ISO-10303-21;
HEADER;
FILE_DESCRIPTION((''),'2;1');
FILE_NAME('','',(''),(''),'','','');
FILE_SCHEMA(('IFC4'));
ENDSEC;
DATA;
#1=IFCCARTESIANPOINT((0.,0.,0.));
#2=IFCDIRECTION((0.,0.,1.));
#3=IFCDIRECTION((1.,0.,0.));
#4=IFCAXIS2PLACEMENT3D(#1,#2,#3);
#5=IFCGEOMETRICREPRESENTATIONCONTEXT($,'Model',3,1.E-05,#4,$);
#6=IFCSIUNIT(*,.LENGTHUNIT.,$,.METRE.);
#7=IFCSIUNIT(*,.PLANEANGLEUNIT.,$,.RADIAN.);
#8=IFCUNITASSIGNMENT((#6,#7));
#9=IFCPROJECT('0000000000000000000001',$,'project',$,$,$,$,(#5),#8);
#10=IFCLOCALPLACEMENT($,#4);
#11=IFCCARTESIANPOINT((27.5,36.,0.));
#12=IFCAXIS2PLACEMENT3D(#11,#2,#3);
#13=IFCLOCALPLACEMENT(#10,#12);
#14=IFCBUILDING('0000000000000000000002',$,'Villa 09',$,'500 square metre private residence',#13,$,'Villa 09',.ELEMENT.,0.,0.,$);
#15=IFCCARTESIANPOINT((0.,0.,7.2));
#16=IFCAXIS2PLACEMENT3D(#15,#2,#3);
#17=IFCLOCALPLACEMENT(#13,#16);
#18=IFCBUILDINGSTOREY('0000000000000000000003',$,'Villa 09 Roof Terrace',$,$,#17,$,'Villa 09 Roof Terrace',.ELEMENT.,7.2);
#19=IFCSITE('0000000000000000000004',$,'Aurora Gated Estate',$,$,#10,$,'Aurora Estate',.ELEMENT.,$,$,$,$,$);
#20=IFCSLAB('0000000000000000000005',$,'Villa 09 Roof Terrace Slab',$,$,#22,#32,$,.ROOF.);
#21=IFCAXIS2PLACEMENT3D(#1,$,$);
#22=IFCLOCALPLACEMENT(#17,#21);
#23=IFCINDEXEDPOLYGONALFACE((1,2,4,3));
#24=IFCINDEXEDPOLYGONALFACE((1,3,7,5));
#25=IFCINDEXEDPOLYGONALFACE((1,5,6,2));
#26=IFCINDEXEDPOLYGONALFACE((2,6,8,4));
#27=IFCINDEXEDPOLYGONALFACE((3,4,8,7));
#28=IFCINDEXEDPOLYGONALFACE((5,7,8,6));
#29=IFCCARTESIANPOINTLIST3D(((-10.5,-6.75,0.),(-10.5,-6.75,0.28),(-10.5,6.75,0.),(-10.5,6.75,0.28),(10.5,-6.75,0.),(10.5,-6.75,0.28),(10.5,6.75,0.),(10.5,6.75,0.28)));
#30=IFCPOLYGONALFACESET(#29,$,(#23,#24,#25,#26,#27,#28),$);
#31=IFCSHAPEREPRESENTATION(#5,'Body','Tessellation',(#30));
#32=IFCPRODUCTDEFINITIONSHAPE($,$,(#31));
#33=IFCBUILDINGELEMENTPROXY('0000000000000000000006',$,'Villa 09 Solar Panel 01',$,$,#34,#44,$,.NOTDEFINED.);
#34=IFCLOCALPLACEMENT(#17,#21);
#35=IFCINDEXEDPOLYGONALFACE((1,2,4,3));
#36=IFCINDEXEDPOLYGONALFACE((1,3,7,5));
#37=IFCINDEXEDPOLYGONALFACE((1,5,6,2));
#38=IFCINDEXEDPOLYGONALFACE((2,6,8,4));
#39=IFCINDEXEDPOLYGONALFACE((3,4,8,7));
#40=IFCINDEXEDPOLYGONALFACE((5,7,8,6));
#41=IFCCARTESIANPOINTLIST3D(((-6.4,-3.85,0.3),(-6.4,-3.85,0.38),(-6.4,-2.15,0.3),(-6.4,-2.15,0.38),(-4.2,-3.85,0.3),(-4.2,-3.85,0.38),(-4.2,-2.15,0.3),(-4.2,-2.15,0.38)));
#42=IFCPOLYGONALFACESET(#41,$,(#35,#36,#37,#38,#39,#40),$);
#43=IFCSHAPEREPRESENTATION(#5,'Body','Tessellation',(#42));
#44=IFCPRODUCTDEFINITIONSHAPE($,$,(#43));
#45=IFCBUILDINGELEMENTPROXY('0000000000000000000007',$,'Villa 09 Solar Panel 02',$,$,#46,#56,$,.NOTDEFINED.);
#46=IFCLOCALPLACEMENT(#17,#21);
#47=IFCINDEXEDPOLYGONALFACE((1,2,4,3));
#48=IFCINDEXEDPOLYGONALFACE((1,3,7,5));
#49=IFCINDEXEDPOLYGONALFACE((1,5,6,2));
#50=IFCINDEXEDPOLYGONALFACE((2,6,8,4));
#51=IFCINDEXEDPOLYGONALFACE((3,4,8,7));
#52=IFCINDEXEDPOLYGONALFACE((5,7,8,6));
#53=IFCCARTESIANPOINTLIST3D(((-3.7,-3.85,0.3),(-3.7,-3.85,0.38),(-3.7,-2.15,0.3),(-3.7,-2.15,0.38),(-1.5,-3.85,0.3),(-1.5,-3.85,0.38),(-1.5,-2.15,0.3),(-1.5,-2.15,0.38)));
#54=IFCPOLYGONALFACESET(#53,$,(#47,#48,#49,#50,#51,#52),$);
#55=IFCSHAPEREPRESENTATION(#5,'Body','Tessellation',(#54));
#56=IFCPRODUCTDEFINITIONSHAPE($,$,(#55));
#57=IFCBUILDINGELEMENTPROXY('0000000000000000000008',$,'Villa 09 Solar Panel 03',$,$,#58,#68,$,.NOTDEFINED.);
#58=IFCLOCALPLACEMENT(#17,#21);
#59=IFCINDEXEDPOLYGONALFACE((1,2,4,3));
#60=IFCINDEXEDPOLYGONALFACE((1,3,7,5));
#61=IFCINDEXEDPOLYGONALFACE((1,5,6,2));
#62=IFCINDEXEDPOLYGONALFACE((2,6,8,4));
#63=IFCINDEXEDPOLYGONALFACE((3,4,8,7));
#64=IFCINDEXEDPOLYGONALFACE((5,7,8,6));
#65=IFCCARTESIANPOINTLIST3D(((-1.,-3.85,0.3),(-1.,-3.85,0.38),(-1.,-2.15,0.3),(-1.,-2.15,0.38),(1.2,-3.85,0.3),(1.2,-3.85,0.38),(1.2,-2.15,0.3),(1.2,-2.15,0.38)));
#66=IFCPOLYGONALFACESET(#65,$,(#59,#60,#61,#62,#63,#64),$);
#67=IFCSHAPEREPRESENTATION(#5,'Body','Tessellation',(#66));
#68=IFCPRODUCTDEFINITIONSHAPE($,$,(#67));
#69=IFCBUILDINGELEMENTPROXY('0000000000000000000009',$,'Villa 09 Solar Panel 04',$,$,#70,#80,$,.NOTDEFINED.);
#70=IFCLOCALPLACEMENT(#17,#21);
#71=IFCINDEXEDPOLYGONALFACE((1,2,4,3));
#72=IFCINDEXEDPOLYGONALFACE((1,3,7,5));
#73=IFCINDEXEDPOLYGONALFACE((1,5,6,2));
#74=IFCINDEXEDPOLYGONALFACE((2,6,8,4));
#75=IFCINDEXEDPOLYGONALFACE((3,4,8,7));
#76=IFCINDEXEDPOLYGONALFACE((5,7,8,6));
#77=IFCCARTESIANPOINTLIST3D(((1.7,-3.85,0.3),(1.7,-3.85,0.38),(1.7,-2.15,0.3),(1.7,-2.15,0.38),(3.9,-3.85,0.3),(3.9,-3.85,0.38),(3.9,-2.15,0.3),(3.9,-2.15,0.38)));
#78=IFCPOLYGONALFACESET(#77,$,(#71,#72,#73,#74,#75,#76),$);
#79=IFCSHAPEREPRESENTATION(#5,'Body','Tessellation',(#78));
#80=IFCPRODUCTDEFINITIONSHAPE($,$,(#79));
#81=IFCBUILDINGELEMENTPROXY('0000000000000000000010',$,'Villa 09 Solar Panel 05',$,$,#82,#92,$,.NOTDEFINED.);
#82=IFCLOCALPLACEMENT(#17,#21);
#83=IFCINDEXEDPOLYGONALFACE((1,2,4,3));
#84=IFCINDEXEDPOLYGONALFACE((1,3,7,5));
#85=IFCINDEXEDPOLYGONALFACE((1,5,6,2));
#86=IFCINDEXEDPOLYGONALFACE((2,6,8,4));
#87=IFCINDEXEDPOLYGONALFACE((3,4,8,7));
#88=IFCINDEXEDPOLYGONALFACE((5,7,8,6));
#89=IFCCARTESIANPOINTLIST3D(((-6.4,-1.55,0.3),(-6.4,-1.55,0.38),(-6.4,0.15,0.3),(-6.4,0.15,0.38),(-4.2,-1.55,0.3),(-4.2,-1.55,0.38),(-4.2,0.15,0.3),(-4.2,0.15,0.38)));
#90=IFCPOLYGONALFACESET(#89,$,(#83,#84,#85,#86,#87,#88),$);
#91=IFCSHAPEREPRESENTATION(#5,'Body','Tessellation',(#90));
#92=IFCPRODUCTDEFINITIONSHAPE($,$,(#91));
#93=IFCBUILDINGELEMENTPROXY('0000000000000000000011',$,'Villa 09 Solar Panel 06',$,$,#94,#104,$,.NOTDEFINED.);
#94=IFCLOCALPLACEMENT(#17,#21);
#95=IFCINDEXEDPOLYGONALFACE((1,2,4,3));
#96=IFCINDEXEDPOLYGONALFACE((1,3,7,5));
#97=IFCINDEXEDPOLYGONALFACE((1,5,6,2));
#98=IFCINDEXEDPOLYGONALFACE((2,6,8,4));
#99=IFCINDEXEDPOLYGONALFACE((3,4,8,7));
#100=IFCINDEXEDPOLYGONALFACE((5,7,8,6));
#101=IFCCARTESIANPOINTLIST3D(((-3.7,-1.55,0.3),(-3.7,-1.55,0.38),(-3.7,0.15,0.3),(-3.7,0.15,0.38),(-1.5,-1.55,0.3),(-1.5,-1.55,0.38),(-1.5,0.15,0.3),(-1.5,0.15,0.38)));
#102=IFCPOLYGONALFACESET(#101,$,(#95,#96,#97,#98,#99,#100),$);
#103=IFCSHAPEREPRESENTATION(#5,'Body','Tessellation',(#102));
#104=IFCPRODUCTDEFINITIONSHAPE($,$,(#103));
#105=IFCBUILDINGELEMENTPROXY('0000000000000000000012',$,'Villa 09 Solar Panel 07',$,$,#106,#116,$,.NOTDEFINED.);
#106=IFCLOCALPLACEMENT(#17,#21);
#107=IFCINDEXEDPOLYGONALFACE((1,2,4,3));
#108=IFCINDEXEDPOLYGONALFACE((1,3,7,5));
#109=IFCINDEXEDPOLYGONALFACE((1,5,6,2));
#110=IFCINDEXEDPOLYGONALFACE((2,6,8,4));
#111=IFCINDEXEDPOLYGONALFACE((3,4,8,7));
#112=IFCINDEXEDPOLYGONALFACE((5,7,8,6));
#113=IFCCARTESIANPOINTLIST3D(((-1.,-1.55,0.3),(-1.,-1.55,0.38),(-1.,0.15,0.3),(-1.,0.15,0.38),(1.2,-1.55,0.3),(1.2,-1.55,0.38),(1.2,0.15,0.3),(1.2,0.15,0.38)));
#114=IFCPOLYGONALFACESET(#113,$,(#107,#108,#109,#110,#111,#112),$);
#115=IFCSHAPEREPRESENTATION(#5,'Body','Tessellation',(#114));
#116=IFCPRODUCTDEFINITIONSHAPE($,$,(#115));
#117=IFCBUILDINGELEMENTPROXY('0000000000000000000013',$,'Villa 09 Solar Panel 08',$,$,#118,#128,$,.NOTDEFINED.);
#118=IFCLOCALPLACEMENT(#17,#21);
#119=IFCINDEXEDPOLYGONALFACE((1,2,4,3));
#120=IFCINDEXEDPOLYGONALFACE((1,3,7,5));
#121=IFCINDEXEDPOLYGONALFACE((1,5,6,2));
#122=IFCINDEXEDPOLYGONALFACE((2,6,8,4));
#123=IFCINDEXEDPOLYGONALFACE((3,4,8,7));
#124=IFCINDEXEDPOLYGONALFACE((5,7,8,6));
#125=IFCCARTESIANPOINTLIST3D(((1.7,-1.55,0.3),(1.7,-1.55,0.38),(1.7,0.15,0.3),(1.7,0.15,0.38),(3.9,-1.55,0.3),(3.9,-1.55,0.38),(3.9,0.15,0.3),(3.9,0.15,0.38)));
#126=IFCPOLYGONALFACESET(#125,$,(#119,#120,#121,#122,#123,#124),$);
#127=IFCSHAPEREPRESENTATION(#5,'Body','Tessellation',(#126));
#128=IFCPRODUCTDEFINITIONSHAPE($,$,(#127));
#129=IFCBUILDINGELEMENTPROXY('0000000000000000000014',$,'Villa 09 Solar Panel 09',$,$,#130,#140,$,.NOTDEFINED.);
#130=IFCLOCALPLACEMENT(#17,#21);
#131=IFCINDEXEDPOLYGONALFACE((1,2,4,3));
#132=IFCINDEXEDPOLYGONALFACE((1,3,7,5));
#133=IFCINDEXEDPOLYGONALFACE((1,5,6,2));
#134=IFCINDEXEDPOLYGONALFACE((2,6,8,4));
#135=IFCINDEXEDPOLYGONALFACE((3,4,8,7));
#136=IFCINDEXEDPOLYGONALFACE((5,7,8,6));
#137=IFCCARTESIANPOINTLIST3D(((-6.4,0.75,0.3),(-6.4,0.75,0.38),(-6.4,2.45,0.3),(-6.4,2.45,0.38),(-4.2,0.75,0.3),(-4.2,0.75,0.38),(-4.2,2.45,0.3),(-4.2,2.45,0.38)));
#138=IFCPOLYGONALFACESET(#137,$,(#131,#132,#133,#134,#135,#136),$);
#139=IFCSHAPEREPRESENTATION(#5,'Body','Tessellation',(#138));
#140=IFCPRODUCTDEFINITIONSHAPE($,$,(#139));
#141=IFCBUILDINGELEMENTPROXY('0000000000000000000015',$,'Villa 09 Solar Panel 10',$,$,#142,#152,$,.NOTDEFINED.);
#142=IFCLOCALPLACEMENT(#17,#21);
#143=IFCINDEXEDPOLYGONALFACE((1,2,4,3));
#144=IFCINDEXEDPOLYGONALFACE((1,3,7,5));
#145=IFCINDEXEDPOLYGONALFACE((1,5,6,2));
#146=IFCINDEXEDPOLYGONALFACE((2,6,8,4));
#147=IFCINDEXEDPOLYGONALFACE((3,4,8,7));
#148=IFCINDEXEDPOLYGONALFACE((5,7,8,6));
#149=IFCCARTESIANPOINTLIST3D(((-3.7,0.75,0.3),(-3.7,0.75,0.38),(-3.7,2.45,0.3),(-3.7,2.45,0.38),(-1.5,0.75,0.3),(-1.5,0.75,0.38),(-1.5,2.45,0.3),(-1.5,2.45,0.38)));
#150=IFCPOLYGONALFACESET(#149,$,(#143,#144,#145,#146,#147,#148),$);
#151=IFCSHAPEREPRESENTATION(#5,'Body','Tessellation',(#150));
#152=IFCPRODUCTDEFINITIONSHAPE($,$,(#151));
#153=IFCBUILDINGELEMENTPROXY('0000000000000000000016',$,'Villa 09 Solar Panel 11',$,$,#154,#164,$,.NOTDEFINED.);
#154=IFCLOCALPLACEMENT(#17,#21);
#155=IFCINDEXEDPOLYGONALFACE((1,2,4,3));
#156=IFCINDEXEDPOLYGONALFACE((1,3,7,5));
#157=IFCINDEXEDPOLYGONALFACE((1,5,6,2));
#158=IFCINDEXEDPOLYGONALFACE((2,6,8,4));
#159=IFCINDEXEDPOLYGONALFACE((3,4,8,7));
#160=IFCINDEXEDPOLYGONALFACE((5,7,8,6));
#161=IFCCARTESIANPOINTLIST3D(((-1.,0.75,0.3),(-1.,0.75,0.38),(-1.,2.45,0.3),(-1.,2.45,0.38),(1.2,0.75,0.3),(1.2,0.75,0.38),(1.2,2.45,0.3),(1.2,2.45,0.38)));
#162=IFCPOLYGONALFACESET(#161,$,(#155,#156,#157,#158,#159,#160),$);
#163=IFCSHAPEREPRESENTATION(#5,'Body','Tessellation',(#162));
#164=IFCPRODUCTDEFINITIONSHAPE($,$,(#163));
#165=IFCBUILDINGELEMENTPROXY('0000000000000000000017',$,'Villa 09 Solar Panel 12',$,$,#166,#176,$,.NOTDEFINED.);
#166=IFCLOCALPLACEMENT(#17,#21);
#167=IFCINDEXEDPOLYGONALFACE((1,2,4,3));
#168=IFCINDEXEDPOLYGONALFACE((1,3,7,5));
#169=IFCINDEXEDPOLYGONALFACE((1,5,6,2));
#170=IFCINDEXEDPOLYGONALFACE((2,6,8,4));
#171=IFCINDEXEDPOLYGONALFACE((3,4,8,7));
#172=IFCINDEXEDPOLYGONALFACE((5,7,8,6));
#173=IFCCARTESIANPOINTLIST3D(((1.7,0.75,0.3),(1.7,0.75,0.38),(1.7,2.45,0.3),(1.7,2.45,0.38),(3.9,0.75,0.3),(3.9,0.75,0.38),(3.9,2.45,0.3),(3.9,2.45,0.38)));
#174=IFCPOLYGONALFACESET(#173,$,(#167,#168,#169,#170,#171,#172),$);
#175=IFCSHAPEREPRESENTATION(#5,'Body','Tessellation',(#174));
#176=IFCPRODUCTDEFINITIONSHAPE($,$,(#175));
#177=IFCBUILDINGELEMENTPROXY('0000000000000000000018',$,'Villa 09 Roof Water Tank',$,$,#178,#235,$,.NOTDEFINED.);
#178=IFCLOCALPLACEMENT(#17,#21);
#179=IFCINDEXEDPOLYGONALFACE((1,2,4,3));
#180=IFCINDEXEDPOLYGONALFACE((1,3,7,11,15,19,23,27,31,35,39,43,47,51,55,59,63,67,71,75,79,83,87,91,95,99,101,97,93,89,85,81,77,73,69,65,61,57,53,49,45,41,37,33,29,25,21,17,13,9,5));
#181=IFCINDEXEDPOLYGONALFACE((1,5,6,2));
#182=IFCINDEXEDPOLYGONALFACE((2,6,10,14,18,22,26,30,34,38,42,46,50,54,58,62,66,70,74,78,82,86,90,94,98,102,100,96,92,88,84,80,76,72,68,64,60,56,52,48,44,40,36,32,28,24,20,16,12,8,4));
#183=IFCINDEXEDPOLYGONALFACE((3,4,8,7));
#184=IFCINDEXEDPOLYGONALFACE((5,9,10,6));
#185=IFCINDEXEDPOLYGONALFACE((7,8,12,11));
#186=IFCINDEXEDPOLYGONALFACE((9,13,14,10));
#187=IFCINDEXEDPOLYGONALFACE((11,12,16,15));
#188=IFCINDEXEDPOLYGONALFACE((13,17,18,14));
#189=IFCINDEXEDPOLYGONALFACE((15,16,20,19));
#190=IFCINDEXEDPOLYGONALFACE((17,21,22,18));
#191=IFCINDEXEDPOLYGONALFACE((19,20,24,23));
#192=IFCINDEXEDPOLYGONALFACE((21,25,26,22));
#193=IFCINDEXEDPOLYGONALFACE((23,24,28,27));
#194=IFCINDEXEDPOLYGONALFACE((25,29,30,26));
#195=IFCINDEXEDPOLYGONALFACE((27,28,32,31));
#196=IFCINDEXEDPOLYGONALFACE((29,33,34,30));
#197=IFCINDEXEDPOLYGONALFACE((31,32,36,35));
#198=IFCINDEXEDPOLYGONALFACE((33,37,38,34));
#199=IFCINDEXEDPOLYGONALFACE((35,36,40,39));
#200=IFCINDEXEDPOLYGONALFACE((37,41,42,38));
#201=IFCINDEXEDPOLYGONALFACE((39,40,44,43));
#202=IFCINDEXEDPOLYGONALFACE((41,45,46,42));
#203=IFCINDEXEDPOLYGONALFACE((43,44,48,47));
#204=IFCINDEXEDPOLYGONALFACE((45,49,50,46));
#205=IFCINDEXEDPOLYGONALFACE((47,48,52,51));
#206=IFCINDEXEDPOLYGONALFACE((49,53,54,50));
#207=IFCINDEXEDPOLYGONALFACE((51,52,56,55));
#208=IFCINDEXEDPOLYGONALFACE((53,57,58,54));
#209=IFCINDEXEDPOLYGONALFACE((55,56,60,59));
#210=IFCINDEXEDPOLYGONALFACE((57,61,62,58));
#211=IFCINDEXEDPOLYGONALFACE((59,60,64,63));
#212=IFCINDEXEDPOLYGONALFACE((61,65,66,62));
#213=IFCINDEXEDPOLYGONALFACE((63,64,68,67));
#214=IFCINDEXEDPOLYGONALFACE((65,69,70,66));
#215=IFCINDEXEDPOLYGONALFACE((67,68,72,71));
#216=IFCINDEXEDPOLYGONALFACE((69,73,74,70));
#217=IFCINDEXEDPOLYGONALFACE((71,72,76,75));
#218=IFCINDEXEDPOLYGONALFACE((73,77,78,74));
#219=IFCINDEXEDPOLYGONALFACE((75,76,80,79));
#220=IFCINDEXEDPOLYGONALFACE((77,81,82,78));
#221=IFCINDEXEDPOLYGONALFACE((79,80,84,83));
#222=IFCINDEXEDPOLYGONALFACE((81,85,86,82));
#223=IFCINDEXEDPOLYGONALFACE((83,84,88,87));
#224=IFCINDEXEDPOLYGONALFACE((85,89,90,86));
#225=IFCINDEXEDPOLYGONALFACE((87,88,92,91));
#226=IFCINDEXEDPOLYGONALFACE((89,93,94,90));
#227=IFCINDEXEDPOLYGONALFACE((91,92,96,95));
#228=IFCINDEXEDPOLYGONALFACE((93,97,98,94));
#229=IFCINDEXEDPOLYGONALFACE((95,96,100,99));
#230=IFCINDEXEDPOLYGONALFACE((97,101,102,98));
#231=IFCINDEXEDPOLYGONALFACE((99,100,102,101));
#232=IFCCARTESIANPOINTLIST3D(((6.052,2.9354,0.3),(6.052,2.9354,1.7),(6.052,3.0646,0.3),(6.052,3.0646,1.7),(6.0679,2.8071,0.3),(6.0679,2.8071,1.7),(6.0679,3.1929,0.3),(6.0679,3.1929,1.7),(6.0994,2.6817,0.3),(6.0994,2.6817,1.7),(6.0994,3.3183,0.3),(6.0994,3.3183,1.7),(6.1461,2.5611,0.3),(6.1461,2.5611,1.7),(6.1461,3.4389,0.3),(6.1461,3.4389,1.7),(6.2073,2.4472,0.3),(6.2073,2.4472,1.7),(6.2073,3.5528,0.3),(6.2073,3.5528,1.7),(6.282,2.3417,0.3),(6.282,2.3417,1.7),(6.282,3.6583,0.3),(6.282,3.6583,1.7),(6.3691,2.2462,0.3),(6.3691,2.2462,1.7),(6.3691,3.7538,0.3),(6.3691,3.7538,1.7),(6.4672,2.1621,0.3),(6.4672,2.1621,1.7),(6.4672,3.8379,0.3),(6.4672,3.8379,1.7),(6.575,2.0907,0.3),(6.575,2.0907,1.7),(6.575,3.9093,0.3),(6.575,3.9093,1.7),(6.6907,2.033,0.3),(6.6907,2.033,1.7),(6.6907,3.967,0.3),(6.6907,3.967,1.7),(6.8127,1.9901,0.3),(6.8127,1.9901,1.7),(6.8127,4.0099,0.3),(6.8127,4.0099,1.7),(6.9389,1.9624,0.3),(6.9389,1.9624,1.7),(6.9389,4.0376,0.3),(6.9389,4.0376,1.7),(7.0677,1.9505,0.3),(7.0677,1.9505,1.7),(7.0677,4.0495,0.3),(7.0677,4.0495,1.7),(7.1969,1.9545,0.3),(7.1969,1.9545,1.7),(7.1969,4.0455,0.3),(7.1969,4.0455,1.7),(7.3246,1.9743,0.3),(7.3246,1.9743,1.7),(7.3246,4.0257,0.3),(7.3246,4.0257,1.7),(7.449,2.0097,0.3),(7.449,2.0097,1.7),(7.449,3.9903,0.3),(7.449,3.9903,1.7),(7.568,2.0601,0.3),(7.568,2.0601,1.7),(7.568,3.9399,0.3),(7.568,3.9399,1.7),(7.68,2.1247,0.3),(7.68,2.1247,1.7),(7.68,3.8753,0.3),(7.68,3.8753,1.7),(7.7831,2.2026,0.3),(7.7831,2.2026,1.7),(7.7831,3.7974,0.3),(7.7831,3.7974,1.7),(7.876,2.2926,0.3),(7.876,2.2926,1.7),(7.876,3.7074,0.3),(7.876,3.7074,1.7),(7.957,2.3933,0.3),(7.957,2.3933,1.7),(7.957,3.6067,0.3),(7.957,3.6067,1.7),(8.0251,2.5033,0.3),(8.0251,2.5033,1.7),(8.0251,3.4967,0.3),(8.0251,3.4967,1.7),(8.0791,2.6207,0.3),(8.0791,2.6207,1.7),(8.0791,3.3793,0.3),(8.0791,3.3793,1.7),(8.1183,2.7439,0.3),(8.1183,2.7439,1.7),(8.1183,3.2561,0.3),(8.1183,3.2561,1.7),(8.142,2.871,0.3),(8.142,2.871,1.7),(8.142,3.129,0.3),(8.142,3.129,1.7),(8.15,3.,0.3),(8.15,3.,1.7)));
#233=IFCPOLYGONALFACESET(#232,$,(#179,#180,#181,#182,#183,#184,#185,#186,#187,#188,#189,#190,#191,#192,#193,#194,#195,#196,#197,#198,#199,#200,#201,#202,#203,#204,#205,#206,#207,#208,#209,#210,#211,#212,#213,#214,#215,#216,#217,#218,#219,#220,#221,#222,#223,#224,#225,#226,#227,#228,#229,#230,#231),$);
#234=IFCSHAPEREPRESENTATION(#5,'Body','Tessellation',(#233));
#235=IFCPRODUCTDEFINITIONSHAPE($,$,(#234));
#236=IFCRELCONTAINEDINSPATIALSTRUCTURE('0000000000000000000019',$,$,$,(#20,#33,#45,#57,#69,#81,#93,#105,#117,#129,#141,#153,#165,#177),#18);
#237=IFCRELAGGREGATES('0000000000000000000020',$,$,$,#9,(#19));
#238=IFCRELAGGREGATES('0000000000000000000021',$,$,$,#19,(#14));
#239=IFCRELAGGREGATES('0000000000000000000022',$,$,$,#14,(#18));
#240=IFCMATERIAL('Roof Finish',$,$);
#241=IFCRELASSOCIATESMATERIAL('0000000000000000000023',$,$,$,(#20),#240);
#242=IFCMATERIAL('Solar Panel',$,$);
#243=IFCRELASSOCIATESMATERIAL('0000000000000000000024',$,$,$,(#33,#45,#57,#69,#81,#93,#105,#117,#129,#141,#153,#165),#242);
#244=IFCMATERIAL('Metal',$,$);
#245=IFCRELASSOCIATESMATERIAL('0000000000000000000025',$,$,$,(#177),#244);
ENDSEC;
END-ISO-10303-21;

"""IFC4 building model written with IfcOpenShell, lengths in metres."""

from ifc_helpers import new_model, si_unit, frame, origin_with_axes, origin_2d_with_axis, place, context, project, spatial, rectangle, circle, extrude, material, element, save


model = new_model("IFC4")

# Units and contexts
model_context = context("Model", 3, precision=1e-05, world=origin_with_axes())
ifc_project = project(units=[si_unit("LENGTHUNIT", "METRE"), si_unit("PLANEANGLEUNIT", "RADIAN")], contexts=[model_context])

# Site, building, storey
site_placement = place(None, origin_with_axes())
site = spatial("IfcSite", under=ifc_project, at=site_placement, Name="Aurora Gated Estate", LongName="Aurora Estate", CompositionType="ELEMENT")
building_placement = place(site_placement, frame((27.5, 36.0, 0.0), z_axis=(0.0, 0.0, 1.0), x_axis=(1.0, 0.0, 0.0)))
building = spatial("IfcBuilding", under=site, at=building_placement, Name="Villa 09", ObjectType="500 square metre private residence", LongName="Villa 09", CompositionType="ELEMENT", ElevationOfRefHeight=0.0, ElevationOfTerrain=0.0)
storey_placement = place(building_placement, frame((0.0, 0.0, 7.2), z_axis=(0.0, 0.0, 1.0), x_axis=(1.0, 0.0, 0.0)))
storey = spatial("IfcBuildingStorey", under=building, at=storey_placement, Name="Villa 09 Roof Terrace", LongName="Villa 09 Roof Terrace", CompositionType="ELEMENT", Elevation=7.2)

# Slab
ifc_material_1 = material(Name="Roof Finish")
slab_placement = place(storey_placement, origin_with_axes())
element("IfcSlab", 1, at=slab_placement, inside=storey, material=ifc_material_1, Name="Villa 09 Roof Terrace Slab", PredefinedType="ROOF", context=model_context, shape_type="SweptSolid", body=[
    extrude(rectangle(XDim=21.0, YDim=13.5, at=origin_2d_with_axis()), origin_with_axes(), (0.0, 0.0, 1.0), 0.28),
])

# Building element proxies
ifc_material_2 = material(Name="Solar Panel")
for number, where, z_axis, x_axis, name in (
    (2, (-5.3, -3.0, 0.3), (0.0, 0.0, 1.0), (1.0, 0.0, 0.0), "Villa 09 Solar Panel 01"),
    (3, (-2.6, -3.0, 0.3), (0.0, 0.0, 1.0), (1.0, 0.0, 0.0), "Villa 09 Solar Panel 02"),
    (4, (0.1, -3.0, 0.3), (0.0, 0.0, 1.0), (1.0, 0.0, 0.0), "Villa 09 Solar Panel 03"),
    (5, (2.8, -3.0, 0.3), (0.0, 0.0, 1.0), (1.0, 0.0, 0.0), "Villa 09 Solar Panel 04"),
    (6, (-5.3, -0.7, 0.3), (0.0, 0.0, 1.0), (1.0, 0.0, 0.0), "Villa 09 Solar Panel 05"),
    (7, (-2.6, -0.7, 0.3), (0.0, 0.0, 1.0), (1.0, 0.0, 0.0), "Villa 09 Solar Panel 06"),
    (8, (0.1, -0.7, 0.3), (0.0, 0.0, 1.0), (1.0, 0.0, 0.0), "Villa 09 Solar Panel 07"),
    (9, (2.8, -0.7, 0.3), (0.0, 0.0, 1.0), (1.0, 0.0, 0.0), "Villa 09 Solar Panel 08"),
    (10, (-5.3, 1.6, 0.3), (0.0, 0.0, 1.0), (1.0, 0.0, 0.0), "Villa 09 Solar Panel 09"),
    (11, (-2.6, 1.6, 0.3), (0.0, 0.0, 1.0), (1.0, 0.0, 0.0), "Villa 09 Solar Panel 10"),
    (12, (0.1, 1.6, 0.3), (0.0, 0.0, 1.0), (1.0, 0.0, 0.0), "Villa 09 Solar Panel 11"),
    (13, (2.8, 1.6, 0.3), (0.0, 0.0, 1.0), (1.0, 0.0, 0.0), "Villa 09 Solar Panel 12"),
):
    element("IfcBuildingElementProxy", number, at=place(storey_placement, frame(where, z_axis=z_axis, x_axis=x_axis)), inside=storey, material=ifc_material_2, Name=name, PredefinedType="NOTDEFINED", context=model_context, shape_type="SweptSolid", body=[
        extrude(rectangle(XDim=2.2, YDim=1.7, at=origin_2d_with_axis()), origin_with_axes(), (0.0, 0.0, 1.0), 0.08),
    ])
ifc_material_3 = material(Name="Metal")
proxy_1_placement = place(storey_placement, frame((7.1, 3.0, 0.3), z_axis=(0.0, 0.0, 1.0), x_axis=(1.0, 0.0, 0.0)))
element("IfcBuildingElementProxy", 14, at=proxy_1_placement, inside=storey, material=ifc_material_3, Name="Villa 09 Roof Water Tank", PredefinedType="NOTDEFINED", context=model_context, shape_type="SweptSolid", body=[
    extrude(circle(Radius=1.05, at=origin_2d_with_axis()), origin_with_axes(), (0.0, 0.0, 1.0), 1.4),
])

save(model, "model.ifc")
